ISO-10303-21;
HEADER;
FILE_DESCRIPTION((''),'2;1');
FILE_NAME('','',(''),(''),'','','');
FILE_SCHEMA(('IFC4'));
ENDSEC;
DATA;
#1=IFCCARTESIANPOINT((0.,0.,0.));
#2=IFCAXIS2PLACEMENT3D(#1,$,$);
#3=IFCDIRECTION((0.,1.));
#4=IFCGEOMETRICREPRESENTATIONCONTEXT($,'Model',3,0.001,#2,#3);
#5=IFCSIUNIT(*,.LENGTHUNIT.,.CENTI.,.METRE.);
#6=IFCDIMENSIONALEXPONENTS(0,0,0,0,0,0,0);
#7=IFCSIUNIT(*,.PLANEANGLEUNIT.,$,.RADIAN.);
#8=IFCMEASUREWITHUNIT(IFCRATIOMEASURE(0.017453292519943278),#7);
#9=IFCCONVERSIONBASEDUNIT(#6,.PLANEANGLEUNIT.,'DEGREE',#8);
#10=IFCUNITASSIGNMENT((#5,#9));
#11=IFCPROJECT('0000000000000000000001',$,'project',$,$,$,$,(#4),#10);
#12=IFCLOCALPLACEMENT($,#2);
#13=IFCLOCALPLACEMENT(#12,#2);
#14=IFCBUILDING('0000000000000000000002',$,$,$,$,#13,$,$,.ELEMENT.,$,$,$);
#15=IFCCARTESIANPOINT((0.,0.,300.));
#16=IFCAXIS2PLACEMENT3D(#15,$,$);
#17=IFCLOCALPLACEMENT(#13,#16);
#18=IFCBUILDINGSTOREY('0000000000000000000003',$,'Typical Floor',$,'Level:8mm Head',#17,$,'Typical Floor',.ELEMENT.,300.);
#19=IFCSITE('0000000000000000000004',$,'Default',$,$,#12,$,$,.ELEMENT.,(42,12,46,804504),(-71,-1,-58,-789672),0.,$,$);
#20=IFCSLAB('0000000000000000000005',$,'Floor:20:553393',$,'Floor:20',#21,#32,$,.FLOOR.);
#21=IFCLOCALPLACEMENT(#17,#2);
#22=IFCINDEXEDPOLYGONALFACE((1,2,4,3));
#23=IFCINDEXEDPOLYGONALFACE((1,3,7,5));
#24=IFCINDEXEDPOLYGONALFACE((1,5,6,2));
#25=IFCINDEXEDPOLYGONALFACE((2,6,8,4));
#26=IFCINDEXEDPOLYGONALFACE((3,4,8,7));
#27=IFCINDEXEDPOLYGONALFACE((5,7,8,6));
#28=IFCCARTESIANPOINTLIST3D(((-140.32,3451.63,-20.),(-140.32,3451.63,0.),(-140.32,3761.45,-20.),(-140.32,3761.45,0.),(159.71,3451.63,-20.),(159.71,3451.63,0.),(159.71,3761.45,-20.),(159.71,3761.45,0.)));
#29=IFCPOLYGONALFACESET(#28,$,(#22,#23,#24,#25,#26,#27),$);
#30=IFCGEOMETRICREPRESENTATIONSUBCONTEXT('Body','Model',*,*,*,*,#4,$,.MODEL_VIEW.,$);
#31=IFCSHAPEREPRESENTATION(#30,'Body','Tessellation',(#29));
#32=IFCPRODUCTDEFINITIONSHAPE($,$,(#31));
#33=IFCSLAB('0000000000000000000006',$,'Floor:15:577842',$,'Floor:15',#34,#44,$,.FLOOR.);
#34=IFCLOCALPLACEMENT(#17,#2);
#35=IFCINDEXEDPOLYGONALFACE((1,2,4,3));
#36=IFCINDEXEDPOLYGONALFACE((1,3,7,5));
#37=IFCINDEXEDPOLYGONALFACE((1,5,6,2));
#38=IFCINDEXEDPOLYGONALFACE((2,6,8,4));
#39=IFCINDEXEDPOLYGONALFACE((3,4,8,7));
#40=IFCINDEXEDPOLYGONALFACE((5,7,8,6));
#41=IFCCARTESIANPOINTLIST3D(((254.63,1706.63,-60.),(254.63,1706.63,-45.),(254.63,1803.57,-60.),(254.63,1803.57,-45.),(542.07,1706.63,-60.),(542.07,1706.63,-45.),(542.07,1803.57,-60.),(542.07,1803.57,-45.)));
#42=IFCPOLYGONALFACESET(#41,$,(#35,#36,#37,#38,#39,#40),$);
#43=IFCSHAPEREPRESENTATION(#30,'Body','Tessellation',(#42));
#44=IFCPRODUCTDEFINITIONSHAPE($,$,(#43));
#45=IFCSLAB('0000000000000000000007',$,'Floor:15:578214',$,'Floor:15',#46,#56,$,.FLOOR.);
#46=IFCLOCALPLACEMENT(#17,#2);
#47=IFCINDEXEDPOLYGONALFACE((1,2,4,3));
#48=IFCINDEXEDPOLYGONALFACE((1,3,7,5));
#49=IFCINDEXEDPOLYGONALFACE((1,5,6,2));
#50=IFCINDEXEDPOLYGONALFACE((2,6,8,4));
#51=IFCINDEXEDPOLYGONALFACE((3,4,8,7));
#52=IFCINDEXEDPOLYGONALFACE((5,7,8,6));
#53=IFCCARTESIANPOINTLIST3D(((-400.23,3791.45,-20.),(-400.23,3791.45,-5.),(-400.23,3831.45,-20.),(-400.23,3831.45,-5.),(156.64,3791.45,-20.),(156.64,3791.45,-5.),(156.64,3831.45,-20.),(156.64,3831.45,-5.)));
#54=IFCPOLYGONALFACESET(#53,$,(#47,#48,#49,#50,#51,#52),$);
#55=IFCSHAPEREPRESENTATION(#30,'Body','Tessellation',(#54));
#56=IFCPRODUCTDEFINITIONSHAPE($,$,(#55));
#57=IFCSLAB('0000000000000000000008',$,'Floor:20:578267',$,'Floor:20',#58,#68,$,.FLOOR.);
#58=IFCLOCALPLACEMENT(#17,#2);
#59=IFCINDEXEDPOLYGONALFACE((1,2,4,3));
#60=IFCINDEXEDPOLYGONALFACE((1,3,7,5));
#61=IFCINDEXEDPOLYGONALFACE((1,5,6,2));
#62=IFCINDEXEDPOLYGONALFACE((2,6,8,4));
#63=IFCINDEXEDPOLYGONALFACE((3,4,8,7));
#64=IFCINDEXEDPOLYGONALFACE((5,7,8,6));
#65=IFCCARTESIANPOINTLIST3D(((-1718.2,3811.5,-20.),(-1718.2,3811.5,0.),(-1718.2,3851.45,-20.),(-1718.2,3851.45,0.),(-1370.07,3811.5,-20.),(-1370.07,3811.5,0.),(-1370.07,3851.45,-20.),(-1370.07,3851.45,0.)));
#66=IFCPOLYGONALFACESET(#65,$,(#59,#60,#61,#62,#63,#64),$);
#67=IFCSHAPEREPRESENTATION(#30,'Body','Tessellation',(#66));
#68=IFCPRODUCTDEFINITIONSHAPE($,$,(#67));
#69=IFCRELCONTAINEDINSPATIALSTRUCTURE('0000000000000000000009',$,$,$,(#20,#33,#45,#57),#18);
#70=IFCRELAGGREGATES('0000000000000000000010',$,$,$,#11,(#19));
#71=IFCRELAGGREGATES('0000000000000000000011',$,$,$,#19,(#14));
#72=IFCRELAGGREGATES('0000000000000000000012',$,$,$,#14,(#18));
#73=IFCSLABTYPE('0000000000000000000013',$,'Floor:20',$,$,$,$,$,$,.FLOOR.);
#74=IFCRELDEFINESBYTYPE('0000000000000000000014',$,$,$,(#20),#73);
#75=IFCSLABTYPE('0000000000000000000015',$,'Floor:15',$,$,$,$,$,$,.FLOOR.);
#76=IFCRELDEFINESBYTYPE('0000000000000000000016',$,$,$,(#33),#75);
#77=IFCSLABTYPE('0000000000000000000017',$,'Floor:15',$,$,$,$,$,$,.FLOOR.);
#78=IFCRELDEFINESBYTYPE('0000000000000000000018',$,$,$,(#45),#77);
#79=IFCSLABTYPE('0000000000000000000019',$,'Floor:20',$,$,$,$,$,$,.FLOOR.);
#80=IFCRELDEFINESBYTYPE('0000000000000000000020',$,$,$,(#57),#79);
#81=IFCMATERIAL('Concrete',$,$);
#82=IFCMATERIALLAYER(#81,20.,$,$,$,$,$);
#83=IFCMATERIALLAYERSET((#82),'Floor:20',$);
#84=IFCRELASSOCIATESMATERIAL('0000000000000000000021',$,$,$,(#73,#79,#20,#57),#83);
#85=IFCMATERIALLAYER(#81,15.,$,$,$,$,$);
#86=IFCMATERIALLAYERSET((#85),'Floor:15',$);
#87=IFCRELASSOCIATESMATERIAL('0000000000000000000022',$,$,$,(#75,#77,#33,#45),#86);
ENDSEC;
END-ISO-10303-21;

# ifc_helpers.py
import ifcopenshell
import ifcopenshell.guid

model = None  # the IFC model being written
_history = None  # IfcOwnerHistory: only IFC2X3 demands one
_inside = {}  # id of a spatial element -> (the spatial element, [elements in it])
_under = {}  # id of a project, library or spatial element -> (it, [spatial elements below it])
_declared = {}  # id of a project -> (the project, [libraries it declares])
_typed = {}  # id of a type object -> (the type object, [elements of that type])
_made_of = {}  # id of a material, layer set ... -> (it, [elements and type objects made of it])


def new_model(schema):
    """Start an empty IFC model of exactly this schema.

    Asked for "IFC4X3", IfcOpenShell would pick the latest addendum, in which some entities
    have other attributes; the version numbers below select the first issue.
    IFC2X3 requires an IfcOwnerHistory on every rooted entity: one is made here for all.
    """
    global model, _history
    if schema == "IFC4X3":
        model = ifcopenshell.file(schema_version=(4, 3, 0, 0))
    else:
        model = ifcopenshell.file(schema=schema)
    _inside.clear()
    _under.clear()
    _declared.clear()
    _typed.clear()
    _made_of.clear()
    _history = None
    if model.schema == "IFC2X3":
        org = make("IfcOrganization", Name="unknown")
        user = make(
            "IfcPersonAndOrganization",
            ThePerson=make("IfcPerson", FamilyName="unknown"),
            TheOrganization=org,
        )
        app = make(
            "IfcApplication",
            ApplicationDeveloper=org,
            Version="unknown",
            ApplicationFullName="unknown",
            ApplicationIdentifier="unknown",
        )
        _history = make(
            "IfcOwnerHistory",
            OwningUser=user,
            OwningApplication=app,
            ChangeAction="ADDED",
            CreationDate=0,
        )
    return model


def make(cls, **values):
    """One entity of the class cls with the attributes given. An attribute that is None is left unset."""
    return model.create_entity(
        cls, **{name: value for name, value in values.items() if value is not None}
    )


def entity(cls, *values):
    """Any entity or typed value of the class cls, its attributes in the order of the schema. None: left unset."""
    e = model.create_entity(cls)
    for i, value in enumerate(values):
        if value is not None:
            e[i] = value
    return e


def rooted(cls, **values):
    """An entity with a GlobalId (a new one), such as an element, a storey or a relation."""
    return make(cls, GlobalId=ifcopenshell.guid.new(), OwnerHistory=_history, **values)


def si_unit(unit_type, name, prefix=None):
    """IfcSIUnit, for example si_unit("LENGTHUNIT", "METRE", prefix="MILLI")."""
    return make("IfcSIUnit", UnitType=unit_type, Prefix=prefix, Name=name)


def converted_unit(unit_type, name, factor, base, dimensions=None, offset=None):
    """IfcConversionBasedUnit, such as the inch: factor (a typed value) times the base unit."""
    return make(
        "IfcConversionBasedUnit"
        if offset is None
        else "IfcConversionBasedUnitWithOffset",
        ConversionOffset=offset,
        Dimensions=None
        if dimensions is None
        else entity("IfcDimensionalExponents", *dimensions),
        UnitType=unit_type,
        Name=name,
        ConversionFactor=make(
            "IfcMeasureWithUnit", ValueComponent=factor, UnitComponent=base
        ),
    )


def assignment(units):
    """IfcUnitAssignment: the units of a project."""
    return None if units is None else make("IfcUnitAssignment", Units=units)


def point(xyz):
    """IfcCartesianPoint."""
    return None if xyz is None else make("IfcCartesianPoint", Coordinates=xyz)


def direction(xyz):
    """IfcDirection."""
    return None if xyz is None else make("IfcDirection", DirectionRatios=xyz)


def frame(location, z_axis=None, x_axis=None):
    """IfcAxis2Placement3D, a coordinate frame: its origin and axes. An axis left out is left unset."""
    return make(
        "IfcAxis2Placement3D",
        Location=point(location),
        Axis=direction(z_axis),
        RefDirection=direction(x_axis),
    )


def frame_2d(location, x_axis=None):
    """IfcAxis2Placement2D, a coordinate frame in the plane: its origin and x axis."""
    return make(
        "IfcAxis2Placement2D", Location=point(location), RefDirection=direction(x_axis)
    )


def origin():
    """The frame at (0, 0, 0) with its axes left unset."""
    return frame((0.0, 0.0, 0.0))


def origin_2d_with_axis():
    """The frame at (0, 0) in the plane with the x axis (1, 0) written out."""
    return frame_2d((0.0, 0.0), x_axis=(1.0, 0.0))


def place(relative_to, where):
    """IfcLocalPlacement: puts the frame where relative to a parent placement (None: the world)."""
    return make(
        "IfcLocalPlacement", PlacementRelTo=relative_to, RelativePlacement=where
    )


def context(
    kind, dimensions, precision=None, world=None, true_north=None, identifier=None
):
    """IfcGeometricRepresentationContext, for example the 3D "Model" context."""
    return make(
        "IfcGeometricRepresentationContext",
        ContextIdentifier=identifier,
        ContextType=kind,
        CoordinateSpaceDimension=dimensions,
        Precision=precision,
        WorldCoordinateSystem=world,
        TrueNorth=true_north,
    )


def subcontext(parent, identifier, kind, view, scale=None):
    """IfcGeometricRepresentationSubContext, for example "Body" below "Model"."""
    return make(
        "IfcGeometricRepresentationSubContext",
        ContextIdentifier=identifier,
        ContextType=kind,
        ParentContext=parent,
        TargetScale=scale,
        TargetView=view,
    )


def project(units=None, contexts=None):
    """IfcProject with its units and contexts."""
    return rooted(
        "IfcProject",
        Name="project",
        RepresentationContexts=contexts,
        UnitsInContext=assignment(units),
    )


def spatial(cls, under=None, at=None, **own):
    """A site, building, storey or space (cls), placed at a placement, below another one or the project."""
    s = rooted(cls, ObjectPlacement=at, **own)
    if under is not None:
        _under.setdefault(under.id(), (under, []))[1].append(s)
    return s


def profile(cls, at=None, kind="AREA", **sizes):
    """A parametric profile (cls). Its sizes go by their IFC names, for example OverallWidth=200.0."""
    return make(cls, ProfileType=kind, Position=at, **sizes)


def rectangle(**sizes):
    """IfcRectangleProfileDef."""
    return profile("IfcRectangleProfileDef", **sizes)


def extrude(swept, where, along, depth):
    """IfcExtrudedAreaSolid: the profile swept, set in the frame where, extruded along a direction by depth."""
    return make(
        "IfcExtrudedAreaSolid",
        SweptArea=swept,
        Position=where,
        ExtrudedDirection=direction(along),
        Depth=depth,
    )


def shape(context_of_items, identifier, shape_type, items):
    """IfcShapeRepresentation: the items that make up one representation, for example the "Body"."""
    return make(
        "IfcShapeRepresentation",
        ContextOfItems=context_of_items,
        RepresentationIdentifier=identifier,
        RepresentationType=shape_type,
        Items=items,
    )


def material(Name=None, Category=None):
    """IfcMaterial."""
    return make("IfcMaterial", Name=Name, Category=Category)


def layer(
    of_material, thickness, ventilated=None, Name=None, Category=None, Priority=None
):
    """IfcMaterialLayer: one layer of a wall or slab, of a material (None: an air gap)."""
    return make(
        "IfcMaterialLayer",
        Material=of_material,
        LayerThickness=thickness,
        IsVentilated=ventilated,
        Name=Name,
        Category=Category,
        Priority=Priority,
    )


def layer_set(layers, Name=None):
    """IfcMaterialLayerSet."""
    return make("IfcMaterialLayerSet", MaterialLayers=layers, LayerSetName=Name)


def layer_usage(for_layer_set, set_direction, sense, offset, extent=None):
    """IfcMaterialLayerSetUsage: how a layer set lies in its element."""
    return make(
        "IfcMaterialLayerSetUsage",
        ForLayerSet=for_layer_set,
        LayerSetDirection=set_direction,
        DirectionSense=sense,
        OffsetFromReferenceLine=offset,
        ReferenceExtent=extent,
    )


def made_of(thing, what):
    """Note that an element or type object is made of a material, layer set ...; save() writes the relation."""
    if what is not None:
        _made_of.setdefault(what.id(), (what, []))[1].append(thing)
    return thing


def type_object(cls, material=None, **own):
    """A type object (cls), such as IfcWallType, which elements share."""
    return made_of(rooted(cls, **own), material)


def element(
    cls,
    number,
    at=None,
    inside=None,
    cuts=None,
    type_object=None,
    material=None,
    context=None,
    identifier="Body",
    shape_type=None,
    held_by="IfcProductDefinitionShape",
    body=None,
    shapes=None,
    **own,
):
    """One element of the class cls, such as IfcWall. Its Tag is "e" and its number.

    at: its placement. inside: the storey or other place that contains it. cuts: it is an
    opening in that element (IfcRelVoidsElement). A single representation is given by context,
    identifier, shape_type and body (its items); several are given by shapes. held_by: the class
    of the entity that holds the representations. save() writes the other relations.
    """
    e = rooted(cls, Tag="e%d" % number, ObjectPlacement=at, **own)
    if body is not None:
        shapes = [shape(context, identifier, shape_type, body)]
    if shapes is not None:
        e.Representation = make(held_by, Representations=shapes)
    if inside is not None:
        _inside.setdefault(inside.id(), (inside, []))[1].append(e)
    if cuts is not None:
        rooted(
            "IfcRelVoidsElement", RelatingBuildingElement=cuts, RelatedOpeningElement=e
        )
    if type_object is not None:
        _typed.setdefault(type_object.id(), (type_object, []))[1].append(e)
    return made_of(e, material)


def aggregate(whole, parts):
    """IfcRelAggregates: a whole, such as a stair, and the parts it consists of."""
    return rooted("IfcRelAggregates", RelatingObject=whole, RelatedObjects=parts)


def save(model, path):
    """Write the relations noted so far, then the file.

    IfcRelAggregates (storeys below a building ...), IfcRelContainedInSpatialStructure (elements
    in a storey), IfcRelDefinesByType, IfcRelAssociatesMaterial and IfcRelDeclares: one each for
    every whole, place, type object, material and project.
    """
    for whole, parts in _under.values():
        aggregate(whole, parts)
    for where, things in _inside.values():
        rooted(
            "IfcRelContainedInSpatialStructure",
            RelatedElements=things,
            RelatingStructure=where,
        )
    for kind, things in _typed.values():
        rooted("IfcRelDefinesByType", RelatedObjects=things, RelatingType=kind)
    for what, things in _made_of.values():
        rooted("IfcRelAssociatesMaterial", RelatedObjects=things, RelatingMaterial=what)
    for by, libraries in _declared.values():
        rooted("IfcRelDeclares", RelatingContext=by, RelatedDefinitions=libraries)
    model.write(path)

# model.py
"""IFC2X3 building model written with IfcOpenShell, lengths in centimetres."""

from ifc_helpers import new_model, entity, si_unit, converted_unit, direction, frame, frame_2d, origin, origin_2d_with_axis, place, context, subcontext, project, spatial, rectangle, extrude, material, layer, layer_set, layer_usage, type_object, element, save


model = new_model("IFC2X3")

# Units and contexts
model_context = context("Model", 3, precision=0.001, world=origin(), true_north=direction((0.0, 1.0)))
body_context = subcontext(model_context, "Body", "Model", "MODEL_VIEW")
ifc_project = project(units=[si_unit("LENGTHUNIT", "METRE", prefix="CENTI"), converted_unit("PLANEANGLEUNIT", "DEGREE", entity("IfcRatioMeasure", 0.017453292519943278), si_unit("PLANEANGLEUNIT", "RADIAN"), dimensions=[0, 0, 0, 0, 0, 0, 0])], contexts=[model_context])

# Site, building, storey
site_placement = place(None, origin())
site = spatial("IfcSite", under=ifc_project, at=site_placement, Name="Default", CompositionType="ELEMENT", RefLatitude=(42, 12, 46, 804504), RefLongitude=(-71, -1, -58, -789672), RefElevation=0.0)
building_placement = place(site_placement, origin())
building = spatial("IfcBuilding", under=site, at=building_placement, CompositionType="ELEMENT")
storey_placement = place(building_placement, frame((0.0, 0.0, 300.0)))
storey = spatial("IfcBuildingStorey", under=building, at=storey_placement, Name="Typical Floor", ObjectType="Level:8mm Head", LongName="Typical Floor", CompositionType="ELEMENT", Elevation=300.0)

# Shared definitions
ifc_material = material(Name="Concrete")

# Slabs
ifc_layer_1 = layer(ifc_material, 20.0)
ifc_layer_set_1 = layer_set([ifc_layer_1], Name="Floor:20")
ifc_layer_usage_1 = layer_usage(ifc_layer_set_1, "AXIS3", "POSITIVE", 0.0)
slab_type_1 = type_object("IfcSlabType", Name="Floor:20", PredefinedType="FLOOR", material=ifc_layer_set_1)
slab_1_placement = place(storey_placement, origin())
element("IfcSlab", 1, at=slab_1_placement, inside=storey, type_object=slab_type_1, material=ifc_layer_usage_1, Name="Floor:20:553393", ObjectType="Floor:20", PredefinedType="FLOOR", context=body_context, shape_type="SweptSolid", body=[
    extrude(rectangle(XDim=309.82, YDim=300.03, at=frame_2d((0.0, 0.0), x_axis=(1.0, 0.0))), frame((9.7, 3606.54, 0.0), z_axis=(0.0, 0.0, -1.0), x_axis=(0.0, 1.0, 0.0)), (0.0, 0.0, 1.0), 20.0),
])
ifc_layer_2 = layer(ifc_material, 15.0)
ifc_layer_set_2 = layer_set([ifc_layer_2], Name="Floor:15")
ifc_layer_usage_2 = layer_usage(ifc_layer_set_2, "AXIS3", "POSITIVE", 0.0)
slab_type_2 = type_object("IfcSlabType", Name="Floor:15", PredefinedType="FLOOR", material=ifc_layer_set_2)
slab_2_placement = place(storey_placement, origin())
element("IfcSlab", 2, at=slab_2_placement, inside=storey, type_object=slab_type_2, material=ifc_layer_usage_2, Name="Floor:15:577842", ObjectType="Floor:15", PredefinedType="FLOOR", context=body_context, shape_type="SweptSolid", body=[
    extrude(rectangle(XDim=96.94, YDim=287.44, at=frame_2d((0.0, 0.0), x_axis=(1.0, 0.0))), frame((398.35, 1755.1, -45.0), z_axis=(0.0, 0.0, -1.0), x_axis=(0.0, 1.0, 0.0)), (0.0, 0.0, 1.0), 15.0),
])
ifc_layer_usage_3 = layer_usage(ifc_layer_set_2, "AXIS3", "POSITIVE", 0.0)
slab_type_3 = type_object("IfcSlabType", Name="Floor:15", PredefinedType="FLOOR", material=ifc_layer_set_2)
slab_3_placement = place(storey_placement, origin())
element("IfcSlab", 3, at=slab_3_placement, inside=storey, type_object=slab_type_3, material=ifc_layer_usage_3, Name="Floor:15:578214", ObjectType="Floor:15", PredefinedType="FLOOR", context=body_context, shape_type="SweptSolid", body=[
    extrude(rectangle(XDim=40.0, YDim=556.87, at=origin_2d_with_axis()), frame((-121.8, 3811.45, -5.0), z_axis=(0.0, 0.0, -1.0), x_axis=(0.0, 1.0, 0.0)), (0.0, 0.0, 1.0), 15.0),
])
ifc_layer_usage_4 = layer_usage(ifc_layer_set_1, "AXIS3", "POSITIVE", 0.0)
slab_type_4 = type_object("IfcSlabType", Name="Floor:20", PredefinedType="FLOOR", material=ifc_layer_set_1)
slab_4_placement = place(storey_placement, origin())
element("IfcSlab", 4, at=slab_4_placement, inside=storey, type_object=slab_type_4, material=ifc_layer_usage_4, Name="Floor:20:578267", ObjectType="Floor:20", PredefinedType="FLOOR", context=body_context, shape_type="SweptSolid", body=[
    extrude(rectangle(XDim=39.95, YDim=348.13, at=frame_2d((0.0, 0.0), x_axis=(1.0, 0.0))), frame((-1544.13, 3831.48, 0.0), z_axis=(0.0, 0.0, -1.0), x_axis=(0.0, 1.0, 0.0)), (0.0, 0.0, 1.0), 20.0),
])

save(model, "model.ifc")
